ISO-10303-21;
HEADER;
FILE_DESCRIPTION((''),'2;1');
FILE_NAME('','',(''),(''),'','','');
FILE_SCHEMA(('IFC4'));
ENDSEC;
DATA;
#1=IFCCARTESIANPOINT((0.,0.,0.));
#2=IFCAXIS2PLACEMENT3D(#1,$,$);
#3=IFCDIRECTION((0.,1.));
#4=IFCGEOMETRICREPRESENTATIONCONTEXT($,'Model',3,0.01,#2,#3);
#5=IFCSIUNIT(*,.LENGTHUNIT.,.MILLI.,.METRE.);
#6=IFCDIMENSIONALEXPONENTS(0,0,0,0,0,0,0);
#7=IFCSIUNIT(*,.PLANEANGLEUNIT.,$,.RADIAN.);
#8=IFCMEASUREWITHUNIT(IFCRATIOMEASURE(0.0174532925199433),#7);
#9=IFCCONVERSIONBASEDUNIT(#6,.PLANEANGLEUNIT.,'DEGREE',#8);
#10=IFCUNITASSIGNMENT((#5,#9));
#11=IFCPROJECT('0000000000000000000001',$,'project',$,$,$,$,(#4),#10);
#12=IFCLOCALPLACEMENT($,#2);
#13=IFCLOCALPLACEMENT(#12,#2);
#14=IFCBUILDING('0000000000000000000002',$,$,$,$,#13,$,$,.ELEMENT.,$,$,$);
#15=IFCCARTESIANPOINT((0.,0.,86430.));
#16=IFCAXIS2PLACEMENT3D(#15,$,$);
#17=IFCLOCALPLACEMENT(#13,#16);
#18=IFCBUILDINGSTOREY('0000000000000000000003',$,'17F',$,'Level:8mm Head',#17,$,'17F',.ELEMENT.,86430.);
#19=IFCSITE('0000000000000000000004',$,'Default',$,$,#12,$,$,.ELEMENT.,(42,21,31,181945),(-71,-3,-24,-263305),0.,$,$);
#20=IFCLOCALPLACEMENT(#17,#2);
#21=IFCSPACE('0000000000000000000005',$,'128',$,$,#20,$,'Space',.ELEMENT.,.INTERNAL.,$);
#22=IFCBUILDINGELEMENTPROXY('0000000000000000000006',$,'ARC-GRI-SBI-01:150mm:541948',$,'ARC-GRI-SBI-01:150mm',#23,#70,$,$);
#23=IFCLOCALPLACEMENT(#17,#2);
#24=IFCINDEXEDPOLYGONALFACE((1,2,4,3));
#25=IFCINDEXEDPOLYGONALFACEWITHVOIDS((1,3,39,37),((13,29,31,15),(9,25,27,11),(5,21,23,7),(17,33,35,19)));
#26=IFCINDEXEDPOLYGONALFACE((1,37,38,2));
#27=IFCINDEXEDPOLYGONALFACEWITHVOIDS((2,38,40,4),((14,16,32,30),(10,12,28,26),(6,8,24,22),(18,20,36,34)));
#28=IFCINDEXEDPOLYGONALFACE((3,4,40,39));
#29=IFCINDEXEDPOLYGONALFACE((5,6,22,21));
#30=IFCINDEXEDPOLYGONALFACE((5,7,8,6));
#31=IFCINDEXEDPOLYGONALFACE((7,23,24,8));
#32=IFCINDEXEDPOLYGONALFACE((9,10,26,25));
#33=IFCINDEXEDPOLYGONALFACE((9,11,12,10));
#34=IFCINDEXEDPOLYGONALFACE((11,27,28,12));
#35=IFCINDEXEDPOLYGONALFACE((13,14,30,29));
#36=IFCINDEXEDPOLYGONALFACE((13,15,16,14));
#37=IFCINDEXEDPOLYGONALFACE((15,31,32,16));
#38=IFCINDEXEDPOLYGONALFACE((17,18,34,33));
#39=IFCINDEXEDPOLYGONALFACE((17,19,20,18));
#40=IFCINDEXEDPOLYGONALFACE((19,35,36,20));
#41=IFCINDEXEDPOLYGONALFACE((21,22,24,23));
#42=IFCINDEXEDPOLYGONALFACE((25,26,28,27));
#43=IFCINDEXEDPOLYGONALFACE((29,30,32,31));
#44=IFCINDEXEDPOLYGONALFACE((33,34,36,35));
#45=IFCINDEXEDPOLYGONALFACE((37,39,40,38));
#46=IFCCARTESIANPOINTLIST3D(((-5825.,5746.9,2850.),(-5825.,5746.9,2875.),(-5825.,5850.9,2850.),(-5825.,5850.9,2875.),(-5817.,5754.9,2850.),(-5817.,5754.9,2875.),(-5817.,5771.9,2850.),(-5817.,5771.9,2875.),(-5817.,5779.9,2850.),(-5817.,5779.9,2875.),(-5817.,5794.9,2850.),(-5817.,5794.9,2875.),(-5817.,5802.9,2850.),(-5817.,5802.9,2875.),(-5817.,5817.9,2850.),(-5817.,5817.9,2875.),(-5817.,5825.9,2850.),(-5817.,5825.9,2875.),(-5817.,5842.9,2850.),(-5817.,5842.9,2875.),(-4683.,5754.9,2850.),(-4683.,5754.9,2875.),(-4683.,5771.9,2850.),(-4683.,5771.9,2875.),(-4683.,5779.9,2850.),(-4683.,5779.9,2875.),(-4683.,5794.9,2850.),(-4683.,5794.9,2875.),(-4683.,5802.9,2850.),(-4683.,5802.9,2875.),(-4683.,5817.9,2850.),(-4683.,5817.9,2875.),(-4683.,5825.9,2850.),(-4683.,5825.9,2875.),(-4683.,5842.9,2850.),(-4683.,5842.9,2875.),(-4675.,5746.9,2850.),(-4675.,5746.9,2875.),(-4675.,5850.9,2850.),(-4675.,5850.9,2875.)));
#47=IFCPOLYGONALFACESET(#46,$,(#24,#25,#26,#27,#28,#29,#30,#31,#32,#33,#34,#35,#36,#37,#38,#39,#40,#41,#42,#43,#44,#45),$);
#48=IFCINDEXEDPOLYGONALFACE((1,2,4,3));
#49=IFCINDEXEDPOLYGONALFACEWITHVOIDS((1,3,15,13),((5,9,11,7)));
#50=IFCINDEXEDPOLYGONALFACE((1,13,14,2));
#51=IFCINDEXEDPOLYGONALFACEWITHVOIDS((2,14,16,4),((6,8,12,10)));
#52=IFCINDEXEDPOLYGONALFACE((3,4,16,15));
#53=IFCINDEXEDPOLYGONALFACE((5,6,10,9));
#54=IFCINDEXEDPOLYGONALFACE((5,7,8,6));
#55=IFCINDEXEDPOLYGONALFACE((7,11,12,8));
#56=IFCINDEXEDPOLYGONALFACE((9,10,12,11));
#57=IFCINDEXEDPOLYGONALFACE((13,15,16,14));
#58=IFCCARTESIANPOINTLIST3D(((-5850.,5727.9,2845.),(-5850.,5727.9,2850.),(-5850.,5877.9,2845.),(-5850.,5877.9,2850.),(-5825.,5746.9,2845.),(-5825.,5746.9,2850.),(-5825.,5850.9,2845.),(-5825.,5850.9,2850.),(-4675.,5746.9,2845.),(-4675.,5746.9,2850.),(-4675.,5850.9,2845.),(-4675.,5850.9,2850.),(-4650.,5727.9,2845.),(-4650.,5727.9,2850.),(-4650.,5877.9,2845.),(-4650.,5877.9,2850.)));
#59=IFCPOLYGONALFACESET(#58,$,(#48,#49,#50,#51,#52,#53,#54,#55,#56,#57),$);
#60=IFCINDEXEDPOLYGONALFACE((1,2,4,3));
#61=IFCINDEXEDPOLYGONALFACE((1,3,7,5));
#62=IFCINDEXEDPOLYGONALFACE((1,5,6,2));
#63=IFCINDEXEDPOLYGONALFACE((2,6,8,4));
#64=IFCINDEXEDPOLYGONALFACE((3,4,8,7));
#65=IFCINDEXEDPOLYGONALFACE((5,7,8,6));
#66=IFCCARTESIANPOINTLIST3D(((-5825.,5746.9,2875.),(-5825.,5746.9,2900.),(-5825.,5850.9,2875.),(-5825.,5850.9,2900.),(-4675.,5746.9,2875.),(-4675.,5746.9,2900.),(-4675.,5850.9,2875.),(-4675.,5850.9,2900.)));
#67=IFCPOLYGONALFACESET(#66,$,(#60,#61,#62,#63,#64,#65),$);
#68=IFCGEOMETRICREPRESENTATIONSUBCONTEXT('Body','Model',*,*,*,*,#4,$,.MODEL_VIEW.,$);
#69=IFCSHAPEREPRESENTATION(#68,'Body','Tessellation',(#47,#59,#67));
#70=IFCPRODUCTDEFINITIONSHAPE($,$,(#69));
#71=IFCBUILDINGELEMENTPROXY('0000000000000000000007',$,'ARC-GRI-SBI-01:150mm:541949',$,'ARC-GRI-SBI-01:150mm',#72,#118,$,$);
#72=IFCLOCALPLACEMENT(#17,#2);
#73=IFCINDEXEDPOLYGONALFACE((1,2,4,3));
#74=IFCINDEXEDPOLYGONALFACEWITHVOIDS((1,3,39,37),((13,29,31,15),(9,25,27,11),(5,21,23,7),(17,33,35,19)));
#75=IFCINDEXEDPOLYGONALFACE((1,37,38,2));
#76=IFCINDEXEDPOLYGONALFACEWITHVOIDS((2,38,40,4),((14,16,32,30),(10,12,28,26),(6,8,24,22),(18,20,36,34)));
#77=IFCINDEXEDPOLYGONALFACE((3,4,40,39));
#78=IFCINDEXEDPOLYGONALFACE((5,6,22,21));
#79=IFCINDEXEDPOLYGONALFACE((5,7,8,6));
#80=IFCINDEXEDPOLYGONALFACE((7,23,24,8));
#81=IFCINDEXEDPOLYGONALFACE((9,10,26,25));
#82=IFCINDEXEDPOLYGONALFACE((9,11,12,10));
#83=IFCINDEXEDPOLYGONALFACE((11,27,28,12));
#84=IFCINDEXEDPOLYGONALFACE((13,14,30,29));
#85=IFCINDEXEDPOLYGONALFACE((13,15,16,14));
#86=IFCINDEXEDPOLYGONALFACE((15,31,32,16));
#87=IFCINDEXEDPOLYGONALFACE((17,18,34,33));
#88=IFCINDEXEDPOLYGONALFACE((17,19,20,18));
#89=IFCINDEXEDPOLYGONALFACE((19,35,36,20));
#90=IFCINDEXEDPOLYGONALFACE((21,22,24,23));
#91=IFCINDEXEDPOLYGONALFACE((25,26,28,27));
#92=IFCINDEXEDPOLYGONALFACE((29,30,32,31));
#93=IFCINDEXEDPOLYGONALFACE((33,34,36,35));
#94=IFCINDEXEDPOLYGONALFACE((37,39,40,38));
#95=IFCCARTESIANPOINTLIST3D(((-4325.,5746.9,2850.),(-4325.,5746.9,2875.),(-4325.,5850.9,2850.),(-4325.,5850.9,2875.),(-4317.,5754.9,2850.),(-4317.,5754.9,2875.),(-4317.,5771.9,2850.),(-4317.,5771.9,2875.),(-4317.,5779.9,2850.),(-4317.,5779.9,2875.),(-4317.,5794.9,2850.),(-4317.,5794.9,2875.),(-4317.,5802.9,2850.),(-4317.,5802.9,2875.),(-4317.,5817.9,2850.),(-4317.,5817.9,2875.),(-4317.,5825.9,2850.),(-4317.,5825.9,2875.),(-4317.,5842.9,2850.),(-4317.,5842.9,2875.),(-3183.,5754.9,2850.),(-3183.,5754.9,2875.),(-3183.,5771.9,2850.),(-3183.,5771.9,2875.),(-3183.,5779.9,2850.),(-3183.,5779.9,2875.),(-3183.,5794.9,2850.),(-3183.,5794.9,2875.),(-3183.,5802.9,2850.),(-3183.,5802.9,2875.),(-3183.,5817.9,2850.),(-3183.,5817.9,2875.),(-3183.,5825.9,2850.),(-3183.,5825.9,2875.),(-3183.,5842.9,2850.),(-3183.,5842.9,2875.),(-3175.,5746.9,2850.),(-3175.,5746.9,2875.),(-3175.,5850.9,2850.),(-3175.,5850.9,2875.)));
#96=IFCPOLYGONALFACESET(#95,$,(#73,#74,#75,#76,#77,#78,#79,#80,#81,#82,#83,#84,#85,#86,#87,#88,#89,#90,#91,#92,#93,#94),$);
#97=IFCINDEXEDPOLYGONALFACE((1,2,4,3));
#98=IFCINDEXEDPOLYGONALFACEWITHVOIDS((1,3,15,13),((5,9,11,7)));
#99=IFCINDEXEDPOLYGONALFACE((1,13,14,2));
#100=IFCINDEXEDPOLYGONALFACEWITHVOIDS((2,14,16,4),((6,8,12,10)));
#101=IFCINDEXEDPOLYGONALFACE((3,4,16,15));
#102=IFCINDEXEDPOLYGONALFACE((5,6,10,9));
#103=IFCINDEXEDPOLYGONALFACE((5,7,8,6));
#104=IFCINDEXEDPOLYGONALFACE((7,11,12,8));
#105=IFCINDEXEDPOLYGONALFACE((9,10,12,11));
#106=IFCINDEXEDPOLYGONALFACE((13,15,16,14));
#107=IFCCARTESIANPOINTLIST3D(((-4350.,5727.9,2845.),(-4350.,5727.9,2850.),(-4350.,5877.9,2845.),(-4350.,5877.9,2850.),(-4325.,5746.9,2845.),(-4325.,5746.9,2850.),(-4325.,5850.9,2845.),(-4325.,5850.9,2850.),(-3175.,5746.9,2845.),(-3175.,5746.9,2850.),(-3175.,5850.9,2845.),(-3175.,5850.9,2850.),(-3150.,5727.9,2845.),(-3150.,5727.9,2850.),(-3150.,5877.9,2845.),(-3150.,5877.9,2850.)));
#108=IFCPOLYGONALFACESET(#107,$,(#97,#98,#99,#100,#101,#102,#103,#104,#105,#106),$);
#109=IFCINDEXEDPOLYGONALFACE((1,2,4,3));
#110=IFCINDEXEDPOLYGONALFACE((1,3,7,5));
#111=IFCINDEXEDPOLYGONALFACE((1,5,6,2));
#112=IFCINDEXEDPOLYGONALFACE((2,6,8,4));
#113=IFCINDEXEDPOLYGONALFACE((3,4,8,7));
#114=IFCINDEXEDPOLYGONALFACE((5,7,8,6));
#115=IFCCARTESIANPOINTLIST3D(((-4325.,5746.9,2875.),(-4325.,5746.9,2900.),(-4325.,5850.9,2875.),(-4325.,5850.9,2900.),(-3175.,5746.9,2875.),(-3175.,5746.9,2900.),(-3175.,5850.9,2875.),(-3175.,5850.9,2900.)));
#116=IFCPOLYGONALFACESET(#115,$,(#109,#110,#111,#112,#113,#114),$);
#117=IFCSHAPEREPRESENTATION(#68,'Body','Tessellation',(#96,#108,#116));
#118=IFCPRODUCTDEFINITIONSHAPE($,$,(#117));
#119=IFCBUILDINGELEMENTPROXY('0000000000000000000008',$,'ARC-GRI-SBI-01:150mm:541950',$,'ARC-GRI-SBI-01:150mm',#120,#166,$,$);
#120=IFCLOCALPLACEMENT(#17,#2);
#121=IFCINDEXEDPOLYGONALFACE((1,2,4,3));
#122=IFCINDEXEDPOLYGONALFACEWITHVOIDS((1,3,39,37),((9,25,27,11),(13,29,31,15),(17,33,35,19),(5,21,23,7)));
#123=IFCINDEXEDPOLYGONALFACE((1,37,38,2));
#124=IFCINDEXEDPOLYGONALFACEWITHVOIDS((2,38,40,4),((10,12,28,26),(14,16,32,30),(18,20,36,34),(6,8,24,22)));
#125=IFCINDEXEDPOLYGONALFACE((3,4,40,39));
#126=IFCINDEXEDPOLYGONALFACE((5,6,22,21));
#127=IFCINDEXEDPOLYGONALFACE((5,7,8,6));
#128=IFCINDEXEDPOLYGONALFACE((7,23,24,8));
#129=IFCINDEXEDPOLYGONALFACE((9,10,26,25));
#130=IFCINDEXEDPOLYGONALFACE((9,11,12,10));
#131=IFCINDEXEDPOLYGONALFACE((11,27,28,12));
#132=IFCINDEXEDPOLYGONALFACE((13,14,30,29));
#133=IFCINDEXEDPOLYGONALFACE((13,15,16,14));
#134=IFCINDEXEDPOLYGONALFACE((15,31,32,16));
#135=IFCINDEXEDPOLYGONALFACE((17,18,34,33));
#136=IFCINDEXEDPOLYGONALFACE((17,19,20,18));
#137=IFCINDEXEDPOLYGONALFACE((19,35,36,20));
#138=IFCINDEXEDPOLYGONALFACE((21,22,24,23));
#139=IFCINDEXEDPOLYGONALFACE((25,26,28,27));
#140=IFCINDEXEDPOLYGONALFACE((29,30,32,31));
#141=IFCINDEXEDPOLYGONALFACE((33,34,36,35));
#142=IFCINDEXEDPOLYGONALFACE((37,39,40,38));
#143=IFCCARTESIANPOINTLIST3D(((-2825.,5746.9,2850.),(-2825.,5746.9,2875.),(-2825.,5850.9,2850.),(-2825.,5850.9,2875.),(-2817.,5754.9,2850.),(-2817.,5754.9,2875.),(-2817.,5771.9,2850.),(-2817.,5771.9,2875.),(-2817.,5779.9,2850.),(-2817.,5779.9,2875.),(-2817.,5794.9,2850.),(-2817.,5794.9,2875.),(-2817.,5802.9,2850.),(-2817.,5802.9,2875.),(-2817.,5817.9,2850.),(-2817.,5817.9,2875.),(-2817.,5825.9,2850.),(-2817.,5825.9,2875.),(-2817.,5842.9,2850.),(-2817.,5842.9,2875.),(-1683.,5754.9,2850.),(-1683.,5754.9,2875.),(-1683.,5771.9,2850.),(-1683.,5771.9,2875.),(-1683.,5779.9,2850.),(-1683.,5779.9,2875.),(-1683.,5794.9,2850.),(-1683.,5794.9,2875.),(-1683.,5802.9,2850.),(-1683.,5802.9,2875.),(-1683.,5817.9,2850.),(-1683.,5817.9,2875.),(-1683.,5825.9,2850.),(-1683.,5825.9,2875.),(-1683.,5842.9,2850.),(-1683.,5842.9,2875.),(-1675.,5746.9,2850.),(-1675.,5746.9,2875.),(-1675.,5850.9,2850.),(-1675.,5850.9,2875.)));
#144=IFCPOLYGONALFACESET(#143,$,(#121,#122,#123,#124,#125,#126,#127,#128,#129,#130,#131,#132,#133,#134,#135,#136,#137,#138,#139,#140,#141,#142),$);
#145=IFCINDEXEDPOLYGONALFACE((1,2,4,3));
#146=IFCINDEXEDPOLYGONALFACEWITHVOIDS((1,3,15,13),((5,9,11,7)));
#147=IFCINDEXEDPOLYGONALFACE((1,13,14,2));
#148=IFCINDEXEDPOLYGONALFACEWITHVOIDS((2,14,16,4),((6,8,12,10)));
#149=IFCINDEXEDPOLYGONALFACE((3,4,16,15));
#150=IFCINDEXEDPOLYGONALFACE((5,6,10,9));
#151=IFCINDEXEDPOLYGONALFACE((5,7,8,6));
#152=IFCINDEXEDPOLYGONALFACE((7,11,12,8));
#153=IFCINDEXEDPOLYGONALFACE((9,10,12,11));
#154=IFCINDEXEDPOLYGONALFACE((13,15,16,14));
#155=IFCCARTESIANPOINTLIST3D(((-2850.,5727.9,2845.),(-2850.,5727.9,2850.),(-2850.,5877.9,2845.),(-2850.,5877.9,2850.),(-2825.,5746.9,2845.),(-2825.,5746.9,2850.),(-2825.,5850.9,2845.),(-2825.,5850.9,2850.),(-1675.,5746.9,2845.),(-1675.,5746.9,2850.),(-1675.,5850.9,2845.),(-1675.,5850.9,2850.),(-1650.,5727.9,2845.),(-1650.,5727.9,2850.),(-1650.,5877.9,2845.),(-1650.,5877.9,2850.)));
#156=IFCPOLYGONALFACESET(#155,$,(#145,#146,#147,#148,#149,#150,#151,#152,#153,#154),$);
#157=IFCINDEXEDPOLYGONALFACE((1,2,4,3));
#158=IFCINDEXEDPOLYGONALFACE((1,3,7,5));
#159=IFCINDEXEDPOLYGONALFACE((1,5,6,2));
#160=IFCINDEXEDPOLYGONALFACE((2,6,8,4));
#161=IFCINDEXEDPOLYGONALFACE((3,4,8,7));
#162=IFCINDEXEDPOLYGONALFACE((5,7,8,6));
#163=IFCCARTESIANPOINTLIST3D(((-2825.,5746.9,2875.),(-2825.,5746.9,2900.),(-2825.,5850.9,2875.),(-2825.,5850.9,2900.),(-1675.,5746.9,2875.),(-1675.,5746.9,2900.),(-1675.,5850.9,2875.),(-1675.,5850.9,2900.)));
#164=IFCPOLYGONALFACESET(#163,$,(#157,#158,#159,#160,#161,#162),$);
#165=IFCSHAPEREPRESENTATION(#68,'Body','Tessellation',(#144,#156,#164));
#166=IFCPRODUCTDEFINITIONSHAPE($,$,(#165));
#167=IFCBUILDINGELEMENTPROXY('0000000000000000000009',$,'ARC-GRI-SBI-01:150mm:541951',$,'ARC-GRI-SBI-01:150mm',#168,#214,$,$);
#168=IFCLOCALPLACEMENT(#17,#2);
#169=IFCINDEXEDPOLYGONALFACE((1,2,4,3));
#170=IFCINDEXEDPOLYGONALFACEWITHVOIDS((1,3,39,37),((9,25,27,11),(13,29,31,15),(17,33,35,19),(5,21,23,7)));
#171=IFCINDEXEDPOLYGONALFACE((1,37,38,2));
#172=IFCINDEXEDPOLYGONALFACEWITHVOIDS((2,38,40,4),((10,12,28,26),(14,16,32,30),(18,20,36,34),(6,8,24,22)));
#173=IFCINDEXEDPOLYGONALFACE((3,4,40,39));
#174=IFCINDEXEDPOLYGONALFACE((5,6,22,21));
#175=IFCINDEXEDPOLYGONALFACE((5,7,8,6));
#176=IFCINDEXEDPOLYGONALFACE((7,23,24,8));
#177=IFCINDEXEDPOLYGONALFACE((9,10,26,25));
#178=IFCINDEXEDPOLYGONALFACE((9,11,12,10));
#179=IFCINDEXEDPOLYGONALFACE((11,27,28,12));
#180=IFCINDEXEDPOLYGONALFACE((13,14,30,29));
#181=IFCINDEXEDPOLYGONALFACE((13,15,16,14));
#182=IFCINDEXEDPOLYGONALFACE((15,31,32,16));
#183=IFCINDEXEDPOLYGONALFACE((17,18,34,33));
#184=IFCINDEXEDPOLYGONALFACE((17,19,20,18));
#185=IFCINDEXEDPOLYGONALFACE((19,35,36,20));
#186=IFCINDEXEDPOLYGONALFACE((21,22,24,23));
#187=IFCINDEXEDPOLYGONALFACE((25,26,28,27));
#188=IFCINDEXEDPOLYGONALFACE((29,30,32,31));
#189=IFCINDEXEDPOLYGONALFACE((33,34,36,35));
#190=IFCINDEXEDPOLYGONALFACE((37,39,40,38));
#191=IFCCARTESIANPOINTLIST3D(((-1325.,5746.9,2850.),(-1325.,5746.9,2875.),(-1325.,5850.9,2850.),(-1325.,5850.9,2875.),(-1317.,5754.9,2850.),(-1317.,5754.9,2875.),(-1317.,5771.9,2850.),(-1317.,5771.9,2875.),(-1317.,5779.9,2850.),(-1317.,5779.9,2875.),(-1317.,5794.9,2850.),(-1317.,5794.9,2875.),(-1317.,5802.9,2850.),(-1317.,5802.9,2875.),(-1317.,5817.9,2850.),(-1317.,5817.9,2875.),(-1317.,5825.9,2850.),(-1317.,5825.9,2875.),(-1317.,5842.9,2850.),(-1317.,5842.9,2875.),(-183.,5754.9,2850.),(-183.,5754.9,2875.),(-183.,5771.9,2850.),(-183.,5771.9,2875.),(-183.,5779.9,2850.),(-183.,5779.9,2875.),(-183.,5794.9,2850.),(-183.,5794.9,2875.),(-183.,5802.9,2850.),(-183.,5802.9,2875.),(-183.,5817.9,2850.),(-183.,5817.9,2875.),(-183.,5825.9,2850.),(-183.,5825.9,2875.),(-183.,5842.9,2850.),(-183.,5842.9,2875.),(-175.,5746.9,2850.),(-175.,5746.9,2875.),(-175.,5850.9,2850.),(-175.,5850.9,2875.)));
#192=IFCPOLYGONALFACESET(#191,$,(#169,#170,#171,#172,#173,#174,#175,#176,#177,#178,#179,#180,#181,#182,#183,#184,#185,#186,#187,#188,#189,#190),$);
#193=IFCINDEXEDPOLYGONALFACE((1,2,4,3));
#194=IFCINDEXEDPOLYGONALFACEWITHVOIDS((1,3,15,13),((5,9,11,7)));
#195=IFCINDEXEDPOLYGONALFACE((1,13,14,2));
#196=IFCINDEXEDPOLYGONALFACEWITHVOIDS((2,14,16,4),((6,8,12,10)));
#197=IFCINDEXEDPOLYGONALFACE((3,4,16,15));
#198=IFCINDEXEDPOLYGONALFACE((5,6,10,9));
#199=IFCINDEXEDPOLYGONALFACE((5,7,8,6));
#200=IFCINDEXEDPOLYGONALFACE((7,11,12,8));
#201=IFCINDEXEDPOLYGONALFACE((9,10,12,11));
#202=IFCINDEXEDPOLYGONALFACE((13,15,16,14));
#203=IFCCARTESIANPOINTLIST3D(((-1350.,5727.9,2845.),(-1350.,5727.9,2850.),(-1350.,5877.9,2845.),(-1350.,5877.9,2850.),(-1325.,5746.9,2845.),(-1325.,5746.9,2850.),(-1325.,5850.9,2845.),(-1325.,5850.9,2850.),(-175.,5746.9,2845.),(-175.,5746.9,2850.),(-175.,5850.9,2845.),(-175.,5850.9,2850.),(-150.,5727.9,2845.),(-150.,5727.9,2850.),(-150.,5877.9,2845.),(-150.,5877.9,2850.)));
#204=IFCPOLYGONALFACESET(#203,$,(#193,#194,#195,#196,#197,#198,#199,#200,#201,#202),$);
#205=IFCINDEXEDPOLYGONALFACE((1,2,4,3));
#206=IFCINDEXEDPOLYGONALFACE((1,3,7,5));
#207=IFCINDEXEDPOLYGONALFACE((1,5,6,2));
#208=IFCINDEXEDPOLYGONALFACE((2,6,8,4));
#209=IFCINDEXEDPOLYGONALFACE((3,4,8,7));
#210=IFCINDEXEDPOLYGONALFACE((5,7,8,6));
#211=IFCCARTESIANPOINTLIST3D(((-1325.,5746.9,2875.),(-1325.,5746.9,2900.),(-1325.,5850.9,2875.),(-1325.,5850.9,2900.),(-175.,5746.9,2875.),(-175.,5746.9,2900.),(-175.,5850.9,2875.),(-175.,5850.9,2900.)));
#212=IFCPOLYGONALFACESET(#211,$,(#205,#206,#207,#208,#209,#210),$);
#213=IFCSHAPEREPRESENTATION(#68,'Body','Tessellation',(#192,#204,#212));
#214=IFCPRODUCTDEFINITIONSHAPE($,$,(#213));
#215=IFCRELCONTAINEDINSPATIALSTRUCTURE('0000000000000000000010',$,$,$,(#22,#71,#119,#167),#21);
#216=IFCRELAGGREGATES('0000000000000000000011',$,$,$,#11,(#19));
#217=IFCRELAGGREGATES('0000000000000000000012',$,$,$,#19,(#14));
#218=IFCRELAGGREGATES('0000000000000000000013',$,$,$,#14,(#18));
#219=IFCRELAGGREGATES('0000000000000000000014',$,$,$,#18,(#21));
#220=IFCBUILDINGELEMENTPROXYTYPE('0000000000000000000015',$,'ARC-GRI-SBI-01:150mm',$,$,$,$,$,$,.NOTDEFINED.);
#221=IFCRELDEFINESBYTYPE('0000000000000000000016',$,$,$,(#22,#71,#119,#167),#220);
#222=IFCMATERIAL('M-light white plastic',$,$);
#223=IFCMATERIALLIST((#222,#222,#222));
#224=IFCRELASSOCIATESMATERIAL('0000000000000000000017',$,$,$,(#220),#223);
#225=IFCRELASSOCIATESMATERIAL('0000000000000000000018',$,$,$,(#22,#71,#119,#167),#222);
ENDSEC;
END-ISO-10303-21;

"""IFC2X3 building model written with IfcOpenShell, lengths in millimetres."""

from ifc_helpers import new_model, entity, si_unit, converted_unit, direction, frame, origin, origin_2d_with_axis, place, context, subcontext, project, spatial, polyline, rectangle, outline, extrude, source, transform, mapped, material, material_list, type_object, type_shapes, element, save


model = new_model("IFC2X3")

# Units and contexts
model_context = context("Model", 3, precision=0.01, world=origin(), true_north=direction((0.0, 1.0)))
body_context = subcontext(model_context, "Body", "Model", "MODEL_VIEW")
ifc_project = project(units=[si_unit("LENGTHUNIT", "METRE", prefix="MILLI"), converted_unit("PLANEANGLEUNIT", "DEGREE", entity("IfcRatioMeasure", 0.0174532925199433), si_unit("PLANEANGLEUNIT", "RADIAN"), dimensions=[0, 0, 0, 0, 0, 0, 0])], contexts=[model_context])

# Site, building, storey
site_placement = place(None, origin())
site = spatial("IfcSite", under=ifc_project, at=site_placement, Name="Default", CompositionType="ELEMENT", RefLatitude=(42, 21, 31, 181945), RefLongitude=(-71, -3, -24, -263305), RefElevation=0.0)
building_placement = place(site_placement, origin())
building = spatial("IfcBuilding", under=site, at=building_placement, CompositionType="ELEMENT")
storey_placement = place(building_placement, frame((0.0, 0.0, 86430.0)))
storey = spatial("IfcBuildingStorey", under=building, at=storey_placement, Name="17F", ObjectType="Level:8mm Head", LongName="17F", CompositionType="ELEMENT", Elevation=86430.0)

# Shared definitions
space_placement = place(storey_placement, origin())
space = spatial("IfcSpace", under=storey, at=space_placement, Name="128", LongName="Space", CompositionType="ELEMENT", InteriorOrExteriorSpace="INTERNAL")

# Building element proxies
ifc_material_1 = material(Name="M-light white plastic")
ifc_material_list = material_list([ifc_material_1, ifc_material_1, ifc_material_1])
building_element_proxy_type = type_object("IfcBuildingElementProxyType", Name="ARC-GRI-SBI-01:150mm", PredefinedType="NOTDEFINED", material=ifc_material_list)
shared_shape = source(origin(), body_context, "Body", "SweptSolid", [
    extrude(outline(polyline([(-575.0, -52.0), (575.0, -52.0), (575.0, 52.0), (-575.0, 52.0), (-575.0, -52.0)]), holes=[polyline([(-567.0, -44.0), (-567.0, -27.0), (567.0, -27.0), (567.0, -44.0), (-567.0, -44.0)]), polyline([(567.0, -4.0), (567.0, -19.0), (-567.0, -19.0), (-567.0, -4.0), (567.0, -4.0)]), polyline([(-567.0, 44.0), (567.0, 44.0), (567.0, 27.0), (-567.0, 27.0), (-567.0, 44.0)]), polyline([(567.0, 4.0), (-567.0, 4.0), (-567.0, 19.0), (567.0, 19.0), (567.0, 4.0)])]), frame((425.0, 4.0, 4000.0), z_axis=(0.0, 0.0, 1.0), x_axis=(-1.0, 0.0, 0.0)), (0.0, 0.0, 1.0), 25.0),
    extrude(outline(polyline([(-600.0, -75.0), (600.0, -75.0), (600.0, 75.0), (-600.0, 75.0), (-600.0, -75.0)]), holes=[polyline([(-575.0, -56.0), (-575.0, 48.0), (575.0, 48.0), (575.0, -56.0), (-575.0, -56.0)])]), frame((425.0, 0.0, 3995.0), z_axis=(0.0, 0.0, 1.0), x_axis=(-1.0, 0.0, 0.0)), (0.0, 0.0, 1.0), 5.0),
    extrude(rectangle(XDim=1150.0, YDim=104.0, at=origin_2d_with_axis()), frame((425.0, 4.0, 4025.0), z_axis=(0.0, 0.0, 1.0), x_axis=(-1.0, 0.0, 0.0)), (0.0, 0.0, 1.0), 25.0),
])
type_shapes(building_element_proxy_type, [shared_shape])
for number, where, z_axis, x_axis, name in (
    (1, (-4825.0, 5802.9, -1150.0), (0.0, 0.0, 1.0), (-1.0, 0.0, 0.0), "ARC-GRI-SBI-01:150mm:541948"),
    (2, (-3325.0, 5802.9, -1150.0), (0.0, 0.0, 1.0), (-1.0, 0.0, 0.0), "ARC-GRI-SBI-01:150mm:541949"),
    (3, (-1825.0, 5802.9, -1150.0), (0.0, 0.0, 1.0), (-1.0, 0.0, 0.0), "ARC-GRI-SBI-01:150mm:541950"),
    (4, (-325.0, 5802.9, -1150.0), (0.0, 0.0, 1.0), (-1.0, 0.0, 0.0), "ARC-GRI-SBI-01:150mm:541951"),
):
    element("IfcBuildingElementProxy", number, at=place(space_placement, frame(where, z_axis=z_axis, x_axis=x_axis)), inside=space, type_object=building_element_proxy_type, material=ifc_material_1, Name=name, ObjectType="ARC-GRI-SBI-01:150mm", context=body_context, shape_type="MappedRepresentation", body=[
        mapped(shared_shape, transform((0.0, 0.0, 0.0), scale=1.0)),
    ])

save(model, "model.ifc")
